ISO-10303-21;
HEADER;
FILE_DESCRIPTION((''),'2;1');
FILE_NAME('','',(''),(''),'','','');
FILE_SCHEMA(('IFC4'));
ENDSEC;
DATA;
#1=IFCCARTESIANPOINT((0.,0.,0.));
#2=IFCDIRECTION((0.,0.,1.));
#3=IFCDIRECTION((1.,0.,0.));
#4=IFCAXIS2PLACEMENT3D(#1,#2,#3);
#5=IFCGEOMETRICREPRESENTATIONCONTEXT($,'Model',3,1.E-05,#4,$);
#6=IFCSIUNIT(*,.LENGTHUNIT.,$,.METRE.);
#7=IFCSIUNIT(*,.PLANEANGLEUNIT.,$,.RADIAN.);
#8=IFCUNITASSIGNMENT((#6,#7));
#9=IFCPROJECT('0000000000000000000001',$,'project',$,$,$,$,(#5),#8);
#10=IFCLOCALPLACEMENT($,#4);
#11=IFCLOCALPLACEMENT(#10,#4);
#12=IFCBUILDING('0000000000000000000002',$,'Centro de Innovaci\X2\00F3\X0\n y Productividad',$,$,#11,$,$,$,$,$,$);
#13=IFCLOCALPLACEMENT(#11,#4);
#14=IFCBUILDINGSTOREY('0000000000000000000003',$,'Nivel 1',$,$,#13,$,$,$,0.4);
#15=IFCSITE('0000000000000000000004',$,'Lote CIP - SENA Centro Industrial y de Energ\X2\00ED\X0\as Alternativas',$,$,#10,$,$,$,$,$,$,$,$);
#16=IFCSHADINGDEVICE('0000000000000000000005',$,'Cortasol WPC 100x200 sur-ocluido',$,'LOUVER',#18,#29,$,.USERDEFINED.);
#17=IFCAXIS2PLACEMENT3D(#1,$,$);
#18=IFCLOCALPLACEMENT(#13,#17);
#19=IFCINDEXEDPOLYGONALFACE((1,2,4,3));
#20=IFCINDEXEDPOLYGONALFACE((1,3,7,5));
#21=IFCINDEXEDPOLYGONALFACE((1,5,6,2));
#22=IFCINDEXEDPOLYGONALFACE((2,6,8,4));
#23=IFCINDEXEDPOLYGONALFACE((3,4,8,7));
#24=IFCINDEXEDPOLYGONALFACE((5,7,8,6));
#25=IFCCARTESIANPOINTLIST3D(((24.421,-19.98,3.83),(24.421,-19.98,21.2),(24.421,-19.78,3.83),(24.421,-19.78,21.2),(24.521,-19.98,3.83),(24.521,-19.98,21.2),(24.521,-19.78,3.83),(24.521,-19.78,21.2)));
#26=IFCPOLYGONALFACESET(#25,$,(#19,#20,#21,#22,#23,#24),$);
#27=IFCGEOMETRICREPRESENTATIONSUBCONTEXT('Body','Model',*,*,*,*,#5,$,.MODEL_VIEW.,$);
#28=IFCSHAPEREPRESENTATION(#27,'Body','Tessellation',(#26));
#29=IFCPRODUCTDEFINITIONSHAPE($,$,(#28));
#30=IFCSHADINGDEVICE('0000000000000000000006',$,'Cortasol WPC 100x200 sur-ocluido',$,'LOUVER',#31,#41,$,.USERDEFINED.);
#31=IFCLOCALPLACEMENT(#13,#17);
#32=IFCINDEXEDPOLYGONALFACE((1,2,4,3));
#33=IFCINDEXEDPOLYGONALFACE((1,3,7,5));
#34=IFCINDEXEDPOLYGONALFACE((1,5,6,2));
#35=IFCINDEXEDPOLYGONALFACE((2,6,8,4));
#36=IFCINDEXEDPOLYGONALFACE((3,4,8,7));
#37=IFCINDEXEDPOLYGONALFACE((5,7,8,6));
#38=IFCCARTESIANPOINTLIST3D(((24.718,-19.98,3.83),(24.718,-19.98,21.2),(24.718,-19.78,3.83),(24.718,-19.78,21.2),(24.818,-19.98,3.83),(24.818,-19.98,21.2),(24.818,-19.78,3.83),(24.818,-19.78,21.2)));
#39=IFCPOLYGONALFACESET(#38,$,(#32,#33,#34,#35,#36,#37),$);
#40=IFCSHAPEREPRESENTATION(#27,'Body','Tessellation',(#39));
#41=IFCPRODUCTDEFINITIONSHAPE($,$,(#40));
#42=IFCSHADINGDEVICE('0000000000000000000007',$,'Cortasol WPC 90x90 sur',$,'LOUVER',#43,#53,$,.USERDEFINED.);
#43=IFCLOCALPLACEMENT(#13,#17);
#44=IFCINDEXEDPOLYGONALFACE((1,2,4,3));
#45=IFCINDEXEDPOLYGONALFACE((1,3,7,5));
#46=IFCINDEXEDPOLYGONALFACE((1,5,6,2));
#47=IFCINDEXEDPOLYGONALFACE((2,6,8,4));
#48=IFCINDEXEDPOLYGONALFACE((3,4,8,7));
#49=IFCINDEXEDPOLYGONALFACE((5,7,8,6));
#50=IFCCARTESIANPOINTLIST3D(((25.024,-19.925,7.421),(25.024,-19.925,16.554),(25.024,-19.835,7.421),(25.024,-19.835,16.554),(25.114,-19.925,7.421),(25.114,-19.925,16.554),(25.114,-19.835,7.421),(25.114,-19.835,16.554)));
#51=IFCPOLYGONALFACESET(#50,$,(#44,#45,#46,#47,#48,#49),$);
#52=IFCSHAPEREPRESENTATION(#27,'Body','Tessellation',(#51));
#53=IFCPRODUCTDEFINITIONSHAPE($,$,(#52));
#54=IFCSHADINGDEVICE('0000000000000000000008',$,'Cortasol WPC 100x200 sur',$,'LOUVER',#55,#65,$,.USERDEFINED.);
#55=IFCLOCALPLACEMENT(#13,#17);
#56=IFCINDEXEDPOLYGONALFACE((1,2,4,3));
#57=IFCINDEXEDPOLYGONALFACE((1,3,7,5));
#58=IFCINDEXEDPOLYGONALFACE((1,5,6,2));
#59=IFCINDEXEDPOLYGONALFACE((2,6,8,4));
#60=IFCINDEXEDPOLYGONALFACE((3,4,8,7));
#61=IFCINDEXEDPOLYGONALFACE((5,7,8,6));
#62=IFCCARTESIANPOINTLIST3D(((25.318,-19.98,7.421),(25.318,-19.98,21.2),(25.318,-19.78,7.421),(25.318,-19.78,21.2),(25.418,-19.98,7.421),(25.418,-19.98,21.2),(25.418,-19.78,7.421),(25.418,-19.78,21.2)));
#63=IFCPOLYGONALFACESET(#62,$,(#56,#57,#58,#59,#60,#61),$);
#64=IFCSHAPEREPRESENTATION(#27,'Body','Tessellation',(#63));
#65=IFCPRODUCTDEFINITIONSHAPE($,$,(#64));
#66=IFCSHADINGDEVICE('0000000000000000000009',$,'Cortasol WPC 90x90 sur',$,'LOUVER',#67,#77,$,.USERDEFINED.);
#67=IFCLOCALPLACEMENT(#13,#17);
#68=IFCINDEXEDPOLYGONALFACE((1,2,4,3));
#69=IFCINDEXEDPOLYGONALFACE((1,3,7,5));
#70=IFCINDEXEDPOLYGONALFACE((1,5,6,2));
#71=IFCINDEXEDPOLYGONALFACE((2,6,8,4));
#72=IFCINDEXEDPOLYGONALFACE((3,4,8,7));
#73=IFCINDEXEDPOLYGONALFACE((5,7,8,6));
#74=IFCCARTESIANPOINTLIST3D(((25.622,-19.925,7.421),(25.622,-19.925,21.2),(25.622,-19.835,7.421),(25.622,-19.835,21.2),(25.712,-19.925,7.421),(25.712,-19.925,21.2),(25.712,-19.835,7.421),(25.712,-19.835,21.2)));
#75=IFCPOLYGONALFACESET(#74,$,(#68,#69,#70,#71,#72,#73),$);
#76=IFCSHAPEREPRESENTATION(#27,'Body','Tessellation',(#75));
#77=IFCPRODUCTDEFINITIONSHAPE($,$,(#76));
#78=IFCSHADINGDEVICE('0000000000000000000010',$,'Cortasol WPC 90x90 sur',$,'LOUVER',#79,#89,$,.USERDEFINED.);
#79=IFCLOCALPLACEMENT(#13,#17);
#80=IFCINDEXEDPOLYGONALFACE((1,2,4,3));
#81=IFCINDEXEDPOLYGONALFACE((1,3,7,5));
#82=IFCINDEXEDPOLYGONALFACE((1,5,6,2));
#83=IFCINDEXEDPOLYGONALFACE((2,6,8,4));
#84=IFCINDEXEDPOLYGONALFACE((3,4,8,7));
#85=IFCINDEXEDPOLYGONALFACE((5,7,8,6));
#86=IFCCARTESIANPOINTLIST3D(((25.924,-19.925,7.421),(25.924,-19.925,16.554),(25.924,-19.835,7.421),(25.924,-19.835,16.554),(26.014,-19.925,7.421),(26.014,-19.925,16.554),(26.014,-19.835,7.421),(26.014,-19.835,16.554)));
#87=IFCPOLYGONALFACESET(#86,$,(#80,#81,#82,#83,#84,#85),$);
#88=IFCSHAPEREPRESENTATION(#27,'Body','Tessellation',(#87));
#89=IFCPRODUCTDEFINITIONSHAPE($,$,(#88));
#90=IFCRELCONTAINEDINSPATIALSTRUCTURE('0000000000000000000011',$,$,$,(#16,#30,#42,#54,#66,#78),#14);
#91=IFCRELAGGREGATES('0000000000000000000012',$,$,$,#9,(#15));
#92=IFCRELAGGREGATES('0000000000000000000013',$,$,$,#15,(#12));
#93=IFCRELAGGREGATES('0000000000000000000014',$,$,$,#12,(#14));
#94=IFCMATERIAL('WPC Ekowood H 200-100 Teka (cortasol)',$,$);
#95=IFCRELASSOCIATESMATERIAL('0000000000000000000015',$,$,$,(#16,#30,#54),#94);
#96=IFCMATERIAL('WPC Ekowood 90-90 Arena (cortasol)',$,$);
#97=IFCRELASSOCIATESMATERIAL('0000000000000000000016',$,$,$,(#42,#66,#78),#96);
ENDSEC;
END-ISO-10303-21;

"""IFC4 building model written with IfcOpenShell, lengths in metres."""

from ifc_helpers import new_model, si_unit, frame, origin_with_axes, place, context, subcontext, project, spatial, polyline, outline, extrude, material, element, save


model = new_model("IFC4")

# Units and contexts
model_context = context("Model", 3, precision=1e-05, world=origin_with_axes())
body_context = subcontext(model_context, "Body", "Model", "MODEL_VIEW")
ifc_project = project(units=[si_unit("LENGTHUNIT", "METRE"), si_unit("PLANEANGLEUNIT", "RADIAN")], contexts=[model_context])

# Site, building, storey
site_placement = place(None, origin_with_axes())
site = spatial("IfcSite", under=ifc_project, at=site_placement, Name="Lote CIP - SENA Centro Industrial y de Energías Alternativas")
building_placement = place(site_placement, origin_with_axes())
building = spatial("IfcBuilding", under=site, at=building_placement, Name="Centro de Innovación y Productividad")
storey_placement = place(building_placement, origin_with_axes())
storey = spatial("IfcBuildingStorey", under=building, at=storey_placement, Name="Nivel 1", Elevation=0.4)

# Shading devices
ifc_material_1 = material(Name="WPC Ekowood H 200-100 Teka (cortasol)")
ifc_material_2 = material(Name="WPC Ekowood 90-90 Arena (cortasol)")
shading_device_1_placement = place(storey_placement, origin_with_axes())
element("IfcShadingDevice", 1, at=shading_device_1_placement, inside=storey, material=ifc_material_1, Name="Cortasol WPC 100x200 sur-ocluido", ObjectType="LOUVER", PredefinedType="USERDEFINED", context=body_context, shape_type="SweptSolid", body=[
    extrude(outline(polyline([(24.421, -19.98), (24.421, -19.78), (24.521, -19.78), (24.521, -19.98), (24.421, -19.98)])), frame((0.0, 0.0, 3.83)), (0.0, 0.0, 1.0), 17.37),
])
shading_device_2_placement = place(storey_placement, origin_with_axes())
element("IfcShadingDevice", 2, at=shading_device_2_placement, inside=storey, material=ifc_material_1, Name="Cortasol WPC 100x200 sur-ocluido", ObjectType="LOUVER", PredefinedType="USERDEFINED", context=body_context, shape_type="SweptSolid", body=[
    extrude(outline(polyline([(24.718, -19.98), (24.718, -19.78), (24.818, -19.78), (24.818, -19.98), (24.718, -19.98)])), frame((0.0, 0.0, 3.83)), (0.0, 0.0, 1.0), 17.37),
])
shading_device_3_placement = place(storey_placement, origin_with_axes())
element("IfcShadingDevice", 3, at=shading_device_3_placement, inside=storey, material=ifc_material_2, Name="Cortasol WPC 90x90 sur", ObjectType="LOUVER", PredefinedType="USERDEFINED", context=body_context, shape_type="SweptSolid", body=[
    extrude(outline(polyline([(25.024, -19.925), (25.024, -19.835), (25.114, -19.835), (25.114, -19.925), (25.024, -19.925)])), frame((0.0, 0.0, 7.421)), (0.0, 0.0, 1.0), 9.133),
])
shading_device_4_placement = place(storey_placement, origin_with_axes())
element("IfcShadingDevice", 4, at=shading_device_4_placement, inside=storey, material=ifc_material_1, Name="Cortasol WPC 100x200 sur", ObjectType="LOUVER", PredefinedType="USERDEFINED", context=body_context, shape_type="SweptSolid", body=[
    extrude(outline(polyline([(25.318, -19.98), (25.318, -19.78), (25.418, -19.78), (25.418, -19.98), (25.318, -19.98)])), frame((0.0, 0.0, 7.421)), (0.0, 0.0, 1.0), 13.779),
])
shading_device_5_placement = place(storey_placement, origin_with_axes())
element("IfcShadingDevice", 5, at=shading_device_5_placement, inside=storey, material=ifc_material_2, Name="Cortasol WPC 90x90 sur", ObjectType="LOUVER", PredefinedType="USERDEFINED", context=body_context, shape_type="SweptSolid", body=[
    extrude(outline(polyline([(25.622, -19.925), (25.622, -19.835), (25.712, -19.835), (25.712, -19.925), (25.622, -19.925)])), frame((0.0, 0.0, 7.421)), (0.0, 0.0, 1.0), 13.779),
])
shading_device_6_placement = place(storey_placement, origin_with_axes())
element("IfcShadingDevice", 6, at=shading_device_6_placement, inside=storey, material=ifc_material_2, Name="Cortasol WPC 90x90 sur", ObjectType="LOUVER", PredefinedType="USERDEFINED", context=body_context, shape_type="SweptSolid", body=[
    extrude(outline(polyline([(25.924, -19.925), (25.924, -19.835), (26.014, -19.835), (26.014, -19.925), (25.924, -19.925)])), frame((0.0, 0.0, 7.421)), (0.0, 0.0, 1.0), 9.133),
])

save(model, "model.ifc")
